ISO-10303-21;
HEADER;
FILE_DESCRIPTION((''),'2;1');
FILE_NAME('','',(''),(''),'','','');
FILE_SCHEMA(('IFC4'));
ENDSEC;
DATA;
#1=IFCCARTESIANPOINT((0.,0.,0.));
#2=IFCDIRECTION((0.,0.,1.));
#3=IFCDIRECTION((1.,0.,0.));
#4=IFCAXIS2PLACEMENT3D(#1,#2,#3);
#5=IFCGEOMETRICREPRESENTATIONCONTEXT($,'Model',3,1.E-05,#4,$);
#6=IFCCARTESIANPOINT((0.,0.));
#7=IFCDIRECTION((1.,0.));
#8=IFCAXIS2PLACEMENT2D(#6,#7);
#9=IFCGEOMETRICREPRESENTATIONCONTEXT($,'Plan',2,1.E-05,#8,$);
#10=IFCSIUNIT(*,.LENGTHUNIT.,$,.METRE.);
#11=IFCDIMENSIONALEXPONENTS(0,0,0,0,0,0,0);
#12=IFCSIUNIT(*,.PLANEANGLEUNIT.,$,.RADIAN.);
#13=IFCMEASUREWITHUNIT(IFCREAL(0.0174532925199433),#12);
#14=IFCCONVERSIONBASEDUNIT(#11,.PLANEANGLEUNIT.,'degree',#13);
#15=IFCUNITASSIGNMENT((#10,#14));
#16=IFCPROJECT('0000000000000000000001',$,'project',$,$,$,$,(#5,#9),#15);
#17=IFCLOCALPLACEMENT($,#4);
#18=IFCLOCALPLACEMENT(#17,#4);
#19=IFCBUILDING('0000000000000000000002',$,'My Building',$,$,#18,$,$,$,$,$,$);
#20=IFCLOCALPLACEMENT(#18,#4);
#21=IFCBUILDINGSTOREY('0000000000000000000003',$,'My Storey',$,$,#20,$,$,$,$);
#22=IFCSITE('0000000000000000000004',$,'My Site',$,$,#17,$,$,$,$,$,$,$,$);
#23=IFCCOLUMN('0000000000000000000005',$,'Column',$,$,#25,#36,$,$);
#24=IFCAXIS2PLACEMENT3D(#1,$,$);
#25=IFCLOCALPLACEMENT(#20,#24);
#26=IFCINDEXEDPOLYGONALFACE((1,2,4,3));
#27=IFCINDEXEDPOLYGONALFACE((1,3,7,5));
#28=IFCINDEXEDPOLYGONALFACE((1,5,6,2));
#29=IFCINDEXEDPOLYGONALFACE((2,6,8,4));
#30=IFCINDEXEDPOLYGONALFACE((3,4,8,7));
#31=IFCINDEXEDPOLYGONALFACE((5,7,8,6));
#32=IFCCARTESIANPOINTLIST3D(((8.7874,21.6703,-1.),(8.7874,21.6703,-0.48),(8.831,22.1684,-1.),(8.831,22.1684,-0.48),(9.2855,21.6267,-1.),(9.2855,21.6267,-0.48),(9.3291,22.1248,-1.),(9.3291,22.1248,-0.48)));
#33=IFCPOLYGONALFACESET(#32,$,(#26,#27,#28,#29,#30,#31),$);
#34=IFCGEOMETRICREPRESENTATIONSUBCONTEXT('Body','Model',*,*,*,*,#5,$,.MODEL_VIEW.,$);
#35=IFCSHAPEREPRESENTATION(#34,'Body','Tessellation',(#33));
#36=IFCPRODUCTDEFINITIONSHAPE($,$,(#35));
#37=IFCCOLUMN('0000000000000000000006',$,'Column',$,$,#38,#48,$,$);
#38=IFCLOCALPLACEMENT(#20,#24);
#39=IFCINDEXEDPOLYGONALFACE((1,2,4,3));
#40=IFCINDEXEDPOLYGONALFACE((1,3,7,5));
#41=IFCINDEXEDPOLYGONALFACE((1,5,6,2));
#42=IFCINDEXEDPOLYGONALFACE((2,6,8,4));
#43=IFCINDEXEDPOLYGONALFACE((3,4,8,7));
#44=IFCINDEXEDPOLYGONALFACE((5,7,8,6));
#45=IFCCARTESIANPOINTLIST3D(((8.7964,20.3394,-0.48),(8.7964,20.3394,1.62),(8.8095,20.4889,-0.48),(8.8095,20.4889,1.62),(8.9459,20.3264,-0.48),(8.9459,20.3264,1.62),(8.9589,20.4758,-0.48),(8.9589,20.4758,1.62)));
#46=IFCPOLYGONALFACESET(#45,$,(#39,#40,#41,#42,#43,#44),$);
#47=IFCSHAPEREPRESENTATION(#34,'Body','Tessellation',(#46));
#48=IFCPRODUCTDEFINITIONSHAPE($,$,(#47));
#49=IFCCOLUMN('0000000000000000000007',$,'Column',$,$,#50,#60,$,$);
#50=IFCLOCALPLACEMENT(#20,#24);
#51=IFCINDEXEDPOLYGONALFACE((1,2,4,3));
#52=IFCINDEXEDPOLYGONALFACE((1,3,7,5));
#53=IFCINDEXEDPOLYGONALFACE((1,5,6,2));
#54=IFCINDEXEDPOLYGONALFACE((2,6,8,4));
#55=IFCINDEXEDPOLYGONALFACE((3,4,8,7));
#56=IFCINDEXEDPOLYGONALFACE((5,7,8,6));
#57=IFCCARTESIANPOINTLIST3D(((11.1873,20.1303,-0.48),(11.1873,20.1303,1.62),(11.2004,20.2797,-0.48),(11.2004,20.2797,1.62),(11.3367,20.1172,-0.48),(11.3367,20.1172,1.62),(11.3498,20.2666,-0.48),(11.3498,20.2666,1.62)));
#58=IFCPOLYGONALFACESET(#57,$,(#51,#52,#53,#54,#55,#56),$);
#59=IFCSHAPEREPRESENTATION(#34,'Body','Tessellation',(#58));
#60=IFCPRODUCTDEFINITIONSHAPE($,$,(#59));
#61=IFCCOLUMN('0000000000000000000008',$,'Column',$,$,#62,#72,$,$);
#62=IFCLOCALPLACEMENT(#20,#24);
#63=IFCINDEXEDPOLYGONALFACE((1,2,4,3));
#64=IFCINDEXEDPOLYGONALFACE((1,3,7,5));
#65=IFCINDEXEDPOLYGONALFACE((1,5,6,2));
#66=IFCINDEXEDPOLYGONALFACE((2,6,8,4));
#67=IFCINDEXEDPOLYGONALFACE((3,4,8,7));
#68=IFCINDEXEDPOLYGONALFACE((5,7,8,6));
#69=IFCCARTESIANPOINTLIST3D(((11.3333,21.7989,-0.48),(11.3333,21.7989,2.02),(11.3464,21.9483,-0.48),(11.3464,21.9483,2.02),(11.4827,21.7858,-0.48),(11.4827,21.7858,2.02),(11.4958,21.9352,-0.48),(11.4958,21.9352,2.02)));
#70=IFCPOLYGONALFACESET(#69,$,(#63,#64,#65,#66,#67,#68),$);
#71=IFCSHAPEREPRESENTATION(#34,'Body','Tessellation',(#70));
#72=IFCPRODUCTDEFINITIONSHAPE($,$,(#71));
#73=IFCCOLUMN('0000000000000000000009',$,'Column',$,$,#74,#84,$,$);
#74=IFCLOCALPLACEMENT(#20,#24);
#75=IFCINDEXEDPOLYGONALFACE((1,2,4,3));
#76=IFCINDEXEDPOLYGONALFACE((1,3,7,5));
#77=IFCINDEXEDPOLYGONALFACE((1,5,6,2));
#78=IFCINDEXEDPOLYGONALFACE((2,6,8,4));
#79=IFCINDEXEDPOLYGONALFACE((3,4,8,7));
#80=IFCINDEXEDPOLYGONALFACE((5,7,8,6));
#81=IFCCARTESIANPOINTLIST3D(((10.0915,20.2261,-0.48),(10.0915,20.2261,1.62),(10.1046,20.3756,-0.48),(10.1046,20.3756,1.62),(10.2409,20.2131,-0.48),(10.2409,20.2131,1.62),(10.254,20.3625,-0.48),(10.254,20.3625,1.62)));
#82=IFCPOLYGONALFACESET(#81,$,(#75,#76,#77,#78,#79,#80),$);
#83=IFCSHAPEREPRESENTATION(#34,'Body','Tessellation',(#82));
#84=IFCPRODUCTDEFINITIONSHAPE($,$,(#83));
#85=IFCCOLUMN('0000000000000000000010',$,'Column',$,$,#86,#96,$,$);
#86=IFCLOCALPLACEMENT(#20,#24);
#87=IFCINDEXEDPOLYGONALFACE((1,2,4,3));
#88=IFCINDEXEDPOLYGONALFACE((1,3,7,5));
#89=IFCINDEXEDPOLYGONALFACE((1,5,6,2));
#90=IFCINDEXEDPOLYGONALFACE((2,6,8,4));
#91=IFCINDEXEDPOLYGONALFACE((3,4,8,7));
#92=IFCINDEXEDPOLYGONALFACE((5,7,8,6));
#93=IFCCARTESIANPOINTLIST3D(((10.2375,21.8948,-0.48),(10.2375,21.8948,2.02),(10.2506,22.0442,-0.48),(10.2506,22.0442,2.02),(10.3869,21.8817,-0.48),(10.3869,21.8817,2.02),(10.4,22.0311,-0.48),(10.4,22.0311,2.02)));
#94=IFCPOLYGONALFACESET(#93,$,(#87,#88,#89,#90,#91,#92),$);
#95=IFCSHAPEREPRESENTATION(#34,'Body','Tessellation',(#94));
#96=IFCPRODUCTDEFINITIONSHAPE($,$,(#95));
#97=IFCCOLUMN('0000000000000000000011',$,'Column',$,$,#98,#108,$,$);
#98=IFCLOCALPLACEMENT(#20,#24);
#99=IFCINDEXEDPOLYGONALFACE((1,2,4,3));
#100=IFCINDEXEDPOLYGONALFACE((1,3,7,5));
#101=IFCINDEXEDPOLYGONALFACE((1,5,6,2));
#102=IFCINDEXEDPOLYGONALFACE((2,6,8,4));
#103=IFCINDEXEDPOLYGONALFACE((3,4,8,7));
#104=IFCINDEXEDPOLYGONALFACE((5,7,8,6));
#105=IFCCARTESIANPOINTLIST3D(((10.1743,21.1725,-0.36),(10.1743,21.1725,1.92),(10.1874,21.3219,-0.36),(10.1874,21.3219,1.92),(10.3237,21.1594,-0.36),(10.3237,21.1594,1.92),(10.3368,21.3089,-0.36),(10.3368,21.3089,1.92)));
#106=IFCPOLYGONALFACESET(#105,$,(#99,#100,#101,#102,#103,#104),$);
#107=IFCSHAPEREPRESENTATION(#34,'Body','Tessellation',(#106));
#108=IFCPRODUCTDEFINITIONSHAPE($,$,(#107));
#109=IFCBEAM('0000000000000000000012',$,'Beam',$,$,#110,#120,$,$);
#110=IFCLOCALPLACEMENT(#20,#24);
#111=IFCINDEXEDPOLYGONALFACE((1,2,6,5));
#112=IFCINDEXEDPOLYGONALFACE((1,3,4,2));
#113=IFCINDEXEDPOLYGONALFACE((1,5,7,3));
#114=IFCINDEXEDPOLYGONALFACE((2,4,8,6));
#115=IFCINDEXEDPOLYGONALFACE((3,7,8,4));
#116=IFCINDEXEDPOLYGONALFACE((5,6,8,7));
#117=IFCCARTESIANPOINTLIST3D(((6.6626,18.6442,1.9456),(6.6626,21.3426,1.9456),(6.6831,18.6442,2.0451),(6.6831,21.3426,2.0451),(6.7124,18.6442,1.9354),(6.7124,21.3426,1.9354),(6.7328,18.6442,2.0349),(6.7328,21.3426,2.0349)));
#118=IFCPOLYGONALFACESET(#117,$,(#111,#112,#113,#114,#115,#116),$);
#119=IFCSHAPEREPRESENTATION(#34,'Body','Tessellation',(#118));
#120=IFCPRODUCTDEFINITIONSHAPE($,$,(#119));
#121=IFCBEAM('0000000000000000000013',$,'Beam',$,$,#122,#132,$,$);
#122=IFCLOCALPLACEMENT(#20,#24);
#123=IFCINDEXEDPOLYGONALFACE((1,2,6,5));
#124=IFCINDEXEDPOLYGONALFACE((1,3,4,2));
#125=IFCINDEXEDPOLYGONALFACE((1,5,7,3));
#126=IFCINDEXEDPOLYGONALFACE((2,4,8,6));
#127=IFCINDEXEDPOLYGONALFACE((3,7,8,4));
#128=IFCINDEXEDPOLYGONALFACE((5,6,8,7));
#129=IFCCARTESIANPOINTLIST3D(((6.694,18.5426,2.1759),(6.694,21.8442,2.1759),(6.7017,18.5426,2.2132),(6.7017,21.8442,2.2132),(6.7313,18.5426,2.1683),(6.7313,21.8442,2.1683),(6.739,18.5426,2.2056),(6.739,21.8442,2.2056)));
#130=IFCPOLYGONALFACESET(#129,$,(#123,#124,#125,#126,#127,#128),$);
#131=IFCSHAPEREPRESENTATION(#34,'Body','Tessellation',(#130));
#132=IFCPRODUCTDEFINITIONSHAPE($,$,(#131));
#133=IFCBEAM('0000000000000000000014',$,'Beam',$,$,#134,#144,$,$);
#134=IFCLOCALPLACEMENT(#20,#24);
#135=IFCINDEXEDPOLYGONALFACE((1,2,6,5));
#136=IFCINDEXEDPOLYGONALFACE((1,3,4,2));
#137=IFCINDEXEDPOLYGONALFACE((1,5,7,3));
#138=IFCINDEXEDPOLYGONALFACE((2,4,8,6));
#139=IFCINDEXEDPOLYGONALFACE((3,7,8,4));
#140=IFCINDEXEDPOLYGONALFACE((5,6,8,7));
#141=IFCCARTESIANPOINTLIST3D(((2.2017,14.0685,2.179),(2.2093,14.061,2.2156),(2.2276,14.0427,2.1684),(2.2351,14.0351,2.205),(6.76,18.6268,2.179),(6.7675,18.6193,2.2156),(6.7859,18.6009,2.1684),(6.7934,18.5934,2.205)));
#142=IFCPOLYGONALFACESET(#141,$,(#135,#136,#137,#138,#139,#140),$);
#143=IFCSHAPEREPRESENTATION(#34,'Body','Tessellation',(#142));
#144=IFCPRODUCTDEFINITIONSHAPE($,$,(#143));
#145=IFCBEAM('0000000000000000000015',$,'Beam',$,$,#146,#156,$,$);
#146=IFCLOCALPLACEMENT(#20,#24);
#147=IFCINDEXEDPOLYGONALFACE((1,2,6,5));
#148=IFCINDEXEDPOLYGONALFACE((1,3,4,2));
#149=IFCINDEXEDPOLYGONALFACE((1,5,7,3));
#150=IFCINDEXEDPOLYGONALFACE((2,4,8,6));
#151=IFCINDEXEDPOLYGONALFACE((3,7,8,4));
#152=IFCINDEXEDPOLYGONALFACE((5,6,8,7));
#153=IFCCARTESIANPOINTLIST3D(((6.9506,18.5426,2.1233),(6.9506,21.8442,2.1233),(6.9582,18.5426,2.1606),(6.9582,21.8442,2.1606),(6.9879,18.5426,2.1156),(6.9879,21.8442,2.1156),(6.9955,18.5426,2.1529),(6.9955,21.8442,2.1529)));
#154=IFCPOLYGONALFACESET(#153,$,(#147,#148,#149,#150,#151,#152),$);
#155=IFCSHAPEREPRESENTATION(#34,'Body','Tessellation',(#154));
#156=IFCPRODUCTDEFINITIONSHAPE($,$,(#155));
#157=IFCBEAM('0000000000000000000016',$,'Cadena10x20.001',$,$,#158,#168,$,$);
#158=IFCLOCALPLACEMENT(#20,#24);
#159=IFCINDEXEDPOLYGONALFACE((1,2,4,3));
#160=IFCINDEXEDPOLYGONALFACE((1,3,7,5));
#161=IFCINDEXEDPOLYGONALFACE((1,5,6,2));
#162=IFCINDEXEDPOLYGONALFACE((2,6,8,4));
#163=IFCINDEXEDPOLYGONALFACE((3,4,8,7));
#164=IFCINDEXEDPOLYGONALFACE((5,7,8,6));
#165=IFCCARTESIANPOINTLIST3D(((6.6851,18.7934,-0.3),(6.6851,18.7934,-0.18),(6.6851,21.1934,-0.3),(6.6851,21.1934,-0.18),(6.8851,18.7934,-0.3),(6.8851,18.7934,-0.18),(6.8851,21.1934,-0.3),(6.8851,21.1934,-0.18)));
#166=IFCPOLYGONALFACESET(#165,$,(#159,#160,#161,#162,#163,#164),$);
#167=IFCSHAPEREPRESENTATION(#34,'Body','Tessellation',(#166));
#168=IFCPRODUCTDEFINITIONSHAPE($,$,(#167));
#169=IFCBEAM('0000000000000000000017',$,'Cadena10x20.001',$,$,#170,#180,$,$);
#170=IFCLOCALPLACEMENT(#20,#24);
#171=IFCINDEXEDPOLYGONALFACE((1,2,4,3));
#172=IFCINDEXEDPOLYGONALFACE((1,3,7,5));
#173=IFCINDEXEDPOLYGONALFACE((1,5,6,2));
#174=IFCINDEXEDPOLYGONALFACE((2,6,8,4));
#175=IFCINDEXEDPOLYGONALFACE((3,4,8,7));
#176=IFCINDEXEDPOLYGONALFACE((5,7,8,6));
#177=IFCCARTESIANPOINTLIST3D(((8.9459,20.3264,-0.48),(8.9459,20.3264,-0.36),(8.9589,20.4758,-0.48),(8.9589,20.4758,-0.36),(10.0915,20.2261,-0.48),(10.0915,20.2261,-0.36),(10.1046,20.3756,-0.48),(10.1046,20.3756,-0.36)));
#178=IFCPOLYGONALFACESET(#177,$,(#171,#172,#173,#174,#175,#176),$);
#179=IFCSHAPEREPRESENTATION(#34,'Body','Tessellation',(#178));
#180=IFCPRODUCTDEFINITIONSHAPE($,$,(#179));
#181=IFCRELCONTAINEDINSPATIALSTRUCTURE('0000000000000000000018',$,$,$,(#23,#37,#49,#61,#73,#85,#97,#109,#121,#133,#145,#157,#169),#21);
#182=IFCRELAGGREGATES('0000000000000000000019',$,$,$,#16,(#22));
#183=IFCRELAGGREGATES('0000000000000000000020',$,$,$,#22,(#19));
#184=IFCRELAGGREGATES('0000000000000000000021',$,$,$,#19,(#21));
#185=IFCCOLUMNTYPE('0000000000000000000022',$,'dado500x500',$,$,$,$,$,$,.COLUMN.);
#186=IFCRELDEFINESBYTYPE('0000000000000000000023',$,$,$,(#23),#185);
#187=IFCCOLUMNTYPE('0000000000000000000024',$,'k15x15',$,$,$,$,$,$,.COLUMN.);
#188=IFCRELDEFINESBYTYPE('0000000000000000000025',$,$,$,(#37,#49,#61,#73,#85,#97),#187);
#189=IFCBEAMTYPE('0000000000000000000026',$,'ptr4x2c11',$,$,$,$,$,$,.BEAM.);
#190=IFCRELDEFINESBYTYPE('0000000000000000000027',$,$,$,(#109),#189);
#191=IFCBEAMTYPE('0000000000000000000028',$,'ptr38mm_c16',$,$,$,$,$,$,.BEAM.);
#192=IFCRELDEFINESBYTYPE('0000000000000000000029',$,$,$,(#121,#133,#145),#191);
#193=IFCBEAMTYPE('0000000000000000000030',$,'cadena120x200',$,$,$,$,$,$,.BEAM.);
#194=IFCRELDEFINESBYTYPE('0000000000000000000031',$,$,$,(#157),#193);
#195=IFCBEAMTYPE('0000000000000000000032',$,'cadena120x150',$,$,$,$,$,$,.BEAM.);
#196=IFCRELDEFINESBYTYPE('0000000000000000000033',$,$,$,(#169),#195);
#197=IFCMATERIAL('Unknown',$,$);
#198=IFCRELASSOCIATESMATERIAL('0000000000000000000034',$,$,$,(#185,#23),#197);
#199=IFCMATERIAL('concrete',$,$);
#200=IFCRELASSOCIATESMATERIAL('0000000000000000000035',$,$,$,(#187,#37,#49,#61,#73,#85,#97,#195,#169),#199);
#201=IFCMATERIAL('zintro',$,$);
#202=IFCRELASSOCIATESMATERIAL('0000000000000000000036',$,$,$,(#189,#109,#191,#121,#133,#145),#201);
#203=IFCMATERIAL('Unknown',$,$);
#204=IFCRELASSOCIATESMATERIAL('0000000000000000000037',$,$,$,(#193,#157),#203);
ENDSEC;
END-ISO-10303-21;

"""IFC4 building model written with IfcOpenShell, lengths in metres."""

from ifc_helpers import new_model, entity, si_unit, converted_unit, frame, origin_with_axes, origin_2d_with_axis, place, context, subcontext, project, spatial, rectangle, extrude, material, material_profile, profile_set, profile_usage, type_object, element, save


model = new_model("IFC4")

# Units and contexts
model_context = context("Model", 3, precision=1e-05, world=origin_with_axes())
plan_context = context("Plan", 2, precision=1e-05, world=origin_2d_with_axis())
body_context = subcontext(model_context, "Body", "Model", "MODEL_VIEW")
ifc_project = project(units=[si_unit("LENGTHUNIT", "METRE"), converted_unit("PLANEANGLEUNIT", "degree", entity("IfcReal", 0.0174532925199433), si_unit("PLANEANGLEUNIT", "RADIAN"), dimensions=[0, 0, 0, 0, 0, 0, 0])], contexts=[model_context, plan_context])

# Site, building, storey
site_placement = place(None, origin_with_axes())
site = spatial("IfcSite", under=ifc_project, at=site_placement, Name="My Site")
building_placement = place(site_placement, origin_with_axes())
building = spatial("IfcBuilding", under=site, at=building_placement, Name="My Building")
storey_placement = place(building_placement, origin_with_axes())
storey = spatial("IfcBuildingStorey", under=building, at=storey_placement, Name="My Storey")

# Columns
ifc_material_1 = material(Name="Unknown")
ifc_material_profile_1 = material_profile(ifc_material_1, rectangle(XDim=0.5, YDim=0.5))
ifc_profile_set_1 = profile_set([ifc_material_profile_1], Name="concrete")
ifc_profile_usage_1 = profile_usage(ifc_profile_set_1)
column_type_1 = type_object("IfcColumnType", Name="dado500x500", PredefinedType="COLUMN", material=ifc_profile_set_1)
column_1_placement = place(storey_placement, frame((9.0582, 21.8975, -1.0), z_axis=(0.0, 0.0, 1.0), x_axis=(0.996195, -0.087156, 0.0)))
element("IfcColumn", 1, at=column_1_placement, inside=storey, type_object=column_type_1, material=ifc_profile_usage_1, Name="Column", context=body_context, shape_type="SweptSolid", body=[
    extrude(rectangle(XDim=0.5, YDim=0.5), origin_with_axes(), (0.0, 0.0, 1.0), 0.52),
])
ifc_material_2 = material(Name="concrete")
ifc_material_profile_2 = material_profile(ifc_material_2, rectangle(XDim=0.15, YDim=0.15))
ifc_profile_set_2 = profile_set([ifc_material_profile_2], Name="concrete")
ifc_profile_usage_2 = profile_usage(ifc_profile_set_2, cardinal=5)
column_type_2 = type_object("IfcColumnType", Name="k15x15", PredefinedType="COLUMN", material=ifc_profile_set_2)
column_2_placement = place(storey_placement, frame((8.8777, 20.4076, -0.48), z_axis=(0.0, 0.0, 1.0), x_axis=(0.996195, -0.087156, 0.0)))
element("IfcColumn", 2, at=column_2_placement, inside=storey, type_object=column_type_2, material=ifc_profile_usage_2, Name="Column", context=body_context, shape_type="SweptSolid", body=[
    extrude(rectangle(XDim=0.15, YDim=0.15), origin_with_axes(), (0.0, 0.0, 1.0), 2.1),
])
ifc_profile_usage_3 = profile_usage(ifc_profile_set_2, cardinal=5)
column_3_placement = place(storey_placement, frame((11.2686, 20.1984, -0.48), z_axis=(0.0, 0.0, 1.0), x_axis=(0.996195, -0.087156, 0.0)))
element("IfcColumn", 3, at=column_3_placement, inside=storey, type_object=column_type_2, material=ifc_profile_usage_3, Name="Column", context=body_context, shape_type="SweptSolid", body=[
    extrude(rectangle(XDim=0.15, YDim=0.15), origin_with_axes(), (0.0, 0.0, 1.0), 2.1),
])
ifc_profile_usage_4 = profile_usage(ifc_profile_set_2, cardinal=5)
column_4_placement = place(storey_placement, frame((11.4145, 21.8671, -0.48), z_axis=(0.0, 0.0, 1.0), x_axis=(0.996195, -0.087156, 0.0)))
element("IfcColumn", 4, at=column_4_placement, inside=storey, type_object=column_type_2, material=ifc_profile_usage_4, Name="Column", context=body_context, shape_type="SweptSolid", body=[
    extrude(rectangle(XDim=0.15, YDim=0.15), origin_with_axes(), (0.0, 0.0, 1.0), 2.5),
])
ifc_profile_usage_5 = profile_usage(ifc_profile_set_2, cardinal=5)
column_5_placement = place(storey_placement, frame((10.1727, 20.2943, -0.48), z_axis=(0.0, 0.0, 1.0), x_axis=(0.996195, -0.087156, 0.0)))
element("IfcColumn", 5, at=column_5_placement, inside=storey, type_object=column_type_2, material=ifc_profile_usage_5, Name="Column", context=body_context, shape_type="SweptSolid", body=[
    extrude(rectangle(XDim=0.15, YDim=0.15), origin_with_axes(), (0.0, 0.0, 1.0), 2.1),
])
ifc_profile_usage_6 = profile_usage(ifc_profile_set_2, cardinal=5)
column_6_placement = place(storey_placement, frame((10.3187, 21.9629, -0.48), z_axis=(0.0, 0.0, 1.0), x_axis=(0.996195, -0.087156, 0.0)))
element("IfcColumn", 6, at=column_6_placement, inside=storey, type_object=column_type_2, material=ifc_profile_usage_6, Name="Column", context=body_context, shape_type="SweptSolid", body=[
    extrude(rectangle(XDim=0.15, YDim=0.15), origin_with_axes(), (0.0, 0.0, 1.0), 2.5),
])
ifc_profile_usage_7 = profile_usage(ifc_profile_set_2, cardinal=5)
column_7_placement = place(storey_placement, frame((10.2555, 21.2407, -0.36), z_axis=(0.0, 0.0, 1.0), x_axis=(0.996195, -0.087156, 0.0)))
element("IfcColumn", 7, at=column_7_placement, inside=storey, type_object=column_type_2, material=ifc_profile_usage_7, Name="Column", context=body_context, shape_type="SweptSolid", body=[
    extrude(rectangle(XDim=0.15, YDim=0.15), origin_with_axes(), (0.0, 0.0, 1.0), 2.28),
])

# Beams
ifc_material_3 = material(Name="zintro")
ifc_material_profile_3 = material_profile(ifc_material_3, rectangle(XDim=0.0508, YDim=0.1016))
ifc_profile_set_3 = profile_set([ifc_material_profile_3])
ifc_profile_usage_8 = profile_usage(ifc_profile_set_3)
beam_type_1 = type_object("IfcBeamType", Name="ptr4x2c11", PredefinedType="BEAM", material=ifc_profile_set_3)
beam_1_placement = place(storey_placement, frame((6.6977, 18.6442, 1.9903), z_axis=(0.0, 1.0, 0.0), x_axis=(-0.979575, 0.0, 0.201078)))
element("IfcBeam", 8, at=beam_1_placement, inside=storey, type_object=beam_type_1, material=ifc_profile_usage_8, Name="Beam", context=body_context, shape_type="SweptSolid", body=[
    extrude(rectangle(XDim=0.0508, YDim=0.1016), origin_with_axes(), (0.0, 0.0, 1.0), 2.6984),
])
ifc_material_profile_4 = material_profile(ifc_material_3, rectangle(XDim=0.0381, YDim=0.0381))
ifc_profile_set_4 = profile_set([ifc_material_profile_4])
ifc_profile_usage_9 = profile_usage(ifc_profile_set_4)
beam_type_2 = type_object("IfcBeamType", Name="ptr38mm_c16", PredefinedType="BEAM", material=ifc_profile_set_4)
beam_2_placement = place(storey_placement, frame((6.7165, 21.8442, 2.1908), z_axis=(0.0, -1.0, 0.0), x_axis=(0.979575, 0.0, -0.201078)))
element("IfcBeam", 9, at=beam_2_placement, inside=storey, type_object=beam_type_2, material=ifc_profile_usage_9, Name="Beam", context=body_context, shape_type="SweptSolid", body=[
    extrude(rectangle(XDim=0.0381, YDim=0.0381), origin_with_axes(), (0.0, 0.0, 1.0), 3.3016),
])
ifc_profile_usage_10 = profile_usage(ifc_profile_set_4)
beam_3_placement = place(storey_placement, frame((6.7767, 18.6101, 2.192), z_axis=(-0.707107, -0.707107, 0.0), x_axis=(0.67903, -0.67903, -0.278991)))
element("IfcBeam", 10, at=beam_3_placement, inside=storey, type_object=beam_type_2, material=ifc_profile_usage_10, Name="Beam", context=body_context, shape_type="SweptSolid", body=[
    extrude(rectangle(XDim=0.0381, YDim=0.0381), origin_with_axes(), (0.0, 0.0, 1.0), 6.4463),
])
ifc_profile_usage_11 = profile_usage(ifc_profile_set_4)
beam_4_placement = place(storey_placement, frame((6.9731, 21.8442, 2.1381), z_axis=(0.0, -1.0, 0.0), x_axis=(0.979575, 0.0, -0.201078)))
element("IfcBeam", 11, at=beam_4_placement, inside=storey, type_object=beam_type_2, material=ifc_profile_usage_11, Name="Beam", context=body_context, shape_type="SweptSolid", body=[
    extrude(rectangle(XDim=0.0381, YDim=0.0381), origin_with_axes(), (0.0, 0.0, 1.0), 3.3016),
])
ifc_material_4 = material(Name="Unknown")
ifc_material_profile_5 = material_profile(ifc_material_4, rectangle(XDim=0.2, YDim=0.12))
ifc_profile_set_5 = profile_set([ifc_material_profile_5], Name="concrete")
ifc_profile_usage_12 = profile_usage(ifc_profile_set_5, cardinal=5)
beam_type_3 = type_object("IfcBeamType", Name="cadena120x200", PredefinedType="BEAM", material=ifc_profile_set_5)
beam_5_placement = place(storey_placement, frame((6.7851, 21.1934, -0.24), z_axis=(0.0, -1.0, 0.0), x_axis=(1.0, 0.0, 0.0)))
element("IfcBeam", 12, at=beam_5_placement, inside=storey, type_object=beam_type_3, material=ifc_profile_usage_12, Name="Cadena10x20.001", context=body_context, shape_type="SweptSolid", body=[
    extrude(rectangle(XDim=0.2, YDim=0.12), origin_with_axes(), (0.0, 0.0, 1.0), 2.4),
])
ifc_material_profile_6 = material_profile(ifc_material_2, rectangle(XDim=0.15, YDim=0.12))
ifc_profile_set_6 = profile_set([ifc_material_profile_6], Name="concrete")
ifc_profile_usage_13 = profile_usage(ifc_profile_set_6)
beam_type_4 = type_object("IfcBeamType", Name="cadena120x150", PredefinedType="BEAM", material=ifc_profile_set_6)
beam_6_placement = place(storey_placement, frame((10.098, 20.3008, -0.42), z_axis=(-0.996195, 0.087155, 0.0), x_axis=(-0.087155, -0.996195, 0.0)))
element("IfcBeam", 13, at=beam_6_placement, inside=storey, type_object=beam_type_4, material=ifc_profile_usage_13, Name="Cadena10x20.001", context=body_context, shape_type="SweptSolid", body=[
    extrude(rectangle(XDim=0.15, YDim=0.12), origin_with_axes(), (0.0, 0.0, 1.0), 1.15),
])

save(model, "model.ifc")
